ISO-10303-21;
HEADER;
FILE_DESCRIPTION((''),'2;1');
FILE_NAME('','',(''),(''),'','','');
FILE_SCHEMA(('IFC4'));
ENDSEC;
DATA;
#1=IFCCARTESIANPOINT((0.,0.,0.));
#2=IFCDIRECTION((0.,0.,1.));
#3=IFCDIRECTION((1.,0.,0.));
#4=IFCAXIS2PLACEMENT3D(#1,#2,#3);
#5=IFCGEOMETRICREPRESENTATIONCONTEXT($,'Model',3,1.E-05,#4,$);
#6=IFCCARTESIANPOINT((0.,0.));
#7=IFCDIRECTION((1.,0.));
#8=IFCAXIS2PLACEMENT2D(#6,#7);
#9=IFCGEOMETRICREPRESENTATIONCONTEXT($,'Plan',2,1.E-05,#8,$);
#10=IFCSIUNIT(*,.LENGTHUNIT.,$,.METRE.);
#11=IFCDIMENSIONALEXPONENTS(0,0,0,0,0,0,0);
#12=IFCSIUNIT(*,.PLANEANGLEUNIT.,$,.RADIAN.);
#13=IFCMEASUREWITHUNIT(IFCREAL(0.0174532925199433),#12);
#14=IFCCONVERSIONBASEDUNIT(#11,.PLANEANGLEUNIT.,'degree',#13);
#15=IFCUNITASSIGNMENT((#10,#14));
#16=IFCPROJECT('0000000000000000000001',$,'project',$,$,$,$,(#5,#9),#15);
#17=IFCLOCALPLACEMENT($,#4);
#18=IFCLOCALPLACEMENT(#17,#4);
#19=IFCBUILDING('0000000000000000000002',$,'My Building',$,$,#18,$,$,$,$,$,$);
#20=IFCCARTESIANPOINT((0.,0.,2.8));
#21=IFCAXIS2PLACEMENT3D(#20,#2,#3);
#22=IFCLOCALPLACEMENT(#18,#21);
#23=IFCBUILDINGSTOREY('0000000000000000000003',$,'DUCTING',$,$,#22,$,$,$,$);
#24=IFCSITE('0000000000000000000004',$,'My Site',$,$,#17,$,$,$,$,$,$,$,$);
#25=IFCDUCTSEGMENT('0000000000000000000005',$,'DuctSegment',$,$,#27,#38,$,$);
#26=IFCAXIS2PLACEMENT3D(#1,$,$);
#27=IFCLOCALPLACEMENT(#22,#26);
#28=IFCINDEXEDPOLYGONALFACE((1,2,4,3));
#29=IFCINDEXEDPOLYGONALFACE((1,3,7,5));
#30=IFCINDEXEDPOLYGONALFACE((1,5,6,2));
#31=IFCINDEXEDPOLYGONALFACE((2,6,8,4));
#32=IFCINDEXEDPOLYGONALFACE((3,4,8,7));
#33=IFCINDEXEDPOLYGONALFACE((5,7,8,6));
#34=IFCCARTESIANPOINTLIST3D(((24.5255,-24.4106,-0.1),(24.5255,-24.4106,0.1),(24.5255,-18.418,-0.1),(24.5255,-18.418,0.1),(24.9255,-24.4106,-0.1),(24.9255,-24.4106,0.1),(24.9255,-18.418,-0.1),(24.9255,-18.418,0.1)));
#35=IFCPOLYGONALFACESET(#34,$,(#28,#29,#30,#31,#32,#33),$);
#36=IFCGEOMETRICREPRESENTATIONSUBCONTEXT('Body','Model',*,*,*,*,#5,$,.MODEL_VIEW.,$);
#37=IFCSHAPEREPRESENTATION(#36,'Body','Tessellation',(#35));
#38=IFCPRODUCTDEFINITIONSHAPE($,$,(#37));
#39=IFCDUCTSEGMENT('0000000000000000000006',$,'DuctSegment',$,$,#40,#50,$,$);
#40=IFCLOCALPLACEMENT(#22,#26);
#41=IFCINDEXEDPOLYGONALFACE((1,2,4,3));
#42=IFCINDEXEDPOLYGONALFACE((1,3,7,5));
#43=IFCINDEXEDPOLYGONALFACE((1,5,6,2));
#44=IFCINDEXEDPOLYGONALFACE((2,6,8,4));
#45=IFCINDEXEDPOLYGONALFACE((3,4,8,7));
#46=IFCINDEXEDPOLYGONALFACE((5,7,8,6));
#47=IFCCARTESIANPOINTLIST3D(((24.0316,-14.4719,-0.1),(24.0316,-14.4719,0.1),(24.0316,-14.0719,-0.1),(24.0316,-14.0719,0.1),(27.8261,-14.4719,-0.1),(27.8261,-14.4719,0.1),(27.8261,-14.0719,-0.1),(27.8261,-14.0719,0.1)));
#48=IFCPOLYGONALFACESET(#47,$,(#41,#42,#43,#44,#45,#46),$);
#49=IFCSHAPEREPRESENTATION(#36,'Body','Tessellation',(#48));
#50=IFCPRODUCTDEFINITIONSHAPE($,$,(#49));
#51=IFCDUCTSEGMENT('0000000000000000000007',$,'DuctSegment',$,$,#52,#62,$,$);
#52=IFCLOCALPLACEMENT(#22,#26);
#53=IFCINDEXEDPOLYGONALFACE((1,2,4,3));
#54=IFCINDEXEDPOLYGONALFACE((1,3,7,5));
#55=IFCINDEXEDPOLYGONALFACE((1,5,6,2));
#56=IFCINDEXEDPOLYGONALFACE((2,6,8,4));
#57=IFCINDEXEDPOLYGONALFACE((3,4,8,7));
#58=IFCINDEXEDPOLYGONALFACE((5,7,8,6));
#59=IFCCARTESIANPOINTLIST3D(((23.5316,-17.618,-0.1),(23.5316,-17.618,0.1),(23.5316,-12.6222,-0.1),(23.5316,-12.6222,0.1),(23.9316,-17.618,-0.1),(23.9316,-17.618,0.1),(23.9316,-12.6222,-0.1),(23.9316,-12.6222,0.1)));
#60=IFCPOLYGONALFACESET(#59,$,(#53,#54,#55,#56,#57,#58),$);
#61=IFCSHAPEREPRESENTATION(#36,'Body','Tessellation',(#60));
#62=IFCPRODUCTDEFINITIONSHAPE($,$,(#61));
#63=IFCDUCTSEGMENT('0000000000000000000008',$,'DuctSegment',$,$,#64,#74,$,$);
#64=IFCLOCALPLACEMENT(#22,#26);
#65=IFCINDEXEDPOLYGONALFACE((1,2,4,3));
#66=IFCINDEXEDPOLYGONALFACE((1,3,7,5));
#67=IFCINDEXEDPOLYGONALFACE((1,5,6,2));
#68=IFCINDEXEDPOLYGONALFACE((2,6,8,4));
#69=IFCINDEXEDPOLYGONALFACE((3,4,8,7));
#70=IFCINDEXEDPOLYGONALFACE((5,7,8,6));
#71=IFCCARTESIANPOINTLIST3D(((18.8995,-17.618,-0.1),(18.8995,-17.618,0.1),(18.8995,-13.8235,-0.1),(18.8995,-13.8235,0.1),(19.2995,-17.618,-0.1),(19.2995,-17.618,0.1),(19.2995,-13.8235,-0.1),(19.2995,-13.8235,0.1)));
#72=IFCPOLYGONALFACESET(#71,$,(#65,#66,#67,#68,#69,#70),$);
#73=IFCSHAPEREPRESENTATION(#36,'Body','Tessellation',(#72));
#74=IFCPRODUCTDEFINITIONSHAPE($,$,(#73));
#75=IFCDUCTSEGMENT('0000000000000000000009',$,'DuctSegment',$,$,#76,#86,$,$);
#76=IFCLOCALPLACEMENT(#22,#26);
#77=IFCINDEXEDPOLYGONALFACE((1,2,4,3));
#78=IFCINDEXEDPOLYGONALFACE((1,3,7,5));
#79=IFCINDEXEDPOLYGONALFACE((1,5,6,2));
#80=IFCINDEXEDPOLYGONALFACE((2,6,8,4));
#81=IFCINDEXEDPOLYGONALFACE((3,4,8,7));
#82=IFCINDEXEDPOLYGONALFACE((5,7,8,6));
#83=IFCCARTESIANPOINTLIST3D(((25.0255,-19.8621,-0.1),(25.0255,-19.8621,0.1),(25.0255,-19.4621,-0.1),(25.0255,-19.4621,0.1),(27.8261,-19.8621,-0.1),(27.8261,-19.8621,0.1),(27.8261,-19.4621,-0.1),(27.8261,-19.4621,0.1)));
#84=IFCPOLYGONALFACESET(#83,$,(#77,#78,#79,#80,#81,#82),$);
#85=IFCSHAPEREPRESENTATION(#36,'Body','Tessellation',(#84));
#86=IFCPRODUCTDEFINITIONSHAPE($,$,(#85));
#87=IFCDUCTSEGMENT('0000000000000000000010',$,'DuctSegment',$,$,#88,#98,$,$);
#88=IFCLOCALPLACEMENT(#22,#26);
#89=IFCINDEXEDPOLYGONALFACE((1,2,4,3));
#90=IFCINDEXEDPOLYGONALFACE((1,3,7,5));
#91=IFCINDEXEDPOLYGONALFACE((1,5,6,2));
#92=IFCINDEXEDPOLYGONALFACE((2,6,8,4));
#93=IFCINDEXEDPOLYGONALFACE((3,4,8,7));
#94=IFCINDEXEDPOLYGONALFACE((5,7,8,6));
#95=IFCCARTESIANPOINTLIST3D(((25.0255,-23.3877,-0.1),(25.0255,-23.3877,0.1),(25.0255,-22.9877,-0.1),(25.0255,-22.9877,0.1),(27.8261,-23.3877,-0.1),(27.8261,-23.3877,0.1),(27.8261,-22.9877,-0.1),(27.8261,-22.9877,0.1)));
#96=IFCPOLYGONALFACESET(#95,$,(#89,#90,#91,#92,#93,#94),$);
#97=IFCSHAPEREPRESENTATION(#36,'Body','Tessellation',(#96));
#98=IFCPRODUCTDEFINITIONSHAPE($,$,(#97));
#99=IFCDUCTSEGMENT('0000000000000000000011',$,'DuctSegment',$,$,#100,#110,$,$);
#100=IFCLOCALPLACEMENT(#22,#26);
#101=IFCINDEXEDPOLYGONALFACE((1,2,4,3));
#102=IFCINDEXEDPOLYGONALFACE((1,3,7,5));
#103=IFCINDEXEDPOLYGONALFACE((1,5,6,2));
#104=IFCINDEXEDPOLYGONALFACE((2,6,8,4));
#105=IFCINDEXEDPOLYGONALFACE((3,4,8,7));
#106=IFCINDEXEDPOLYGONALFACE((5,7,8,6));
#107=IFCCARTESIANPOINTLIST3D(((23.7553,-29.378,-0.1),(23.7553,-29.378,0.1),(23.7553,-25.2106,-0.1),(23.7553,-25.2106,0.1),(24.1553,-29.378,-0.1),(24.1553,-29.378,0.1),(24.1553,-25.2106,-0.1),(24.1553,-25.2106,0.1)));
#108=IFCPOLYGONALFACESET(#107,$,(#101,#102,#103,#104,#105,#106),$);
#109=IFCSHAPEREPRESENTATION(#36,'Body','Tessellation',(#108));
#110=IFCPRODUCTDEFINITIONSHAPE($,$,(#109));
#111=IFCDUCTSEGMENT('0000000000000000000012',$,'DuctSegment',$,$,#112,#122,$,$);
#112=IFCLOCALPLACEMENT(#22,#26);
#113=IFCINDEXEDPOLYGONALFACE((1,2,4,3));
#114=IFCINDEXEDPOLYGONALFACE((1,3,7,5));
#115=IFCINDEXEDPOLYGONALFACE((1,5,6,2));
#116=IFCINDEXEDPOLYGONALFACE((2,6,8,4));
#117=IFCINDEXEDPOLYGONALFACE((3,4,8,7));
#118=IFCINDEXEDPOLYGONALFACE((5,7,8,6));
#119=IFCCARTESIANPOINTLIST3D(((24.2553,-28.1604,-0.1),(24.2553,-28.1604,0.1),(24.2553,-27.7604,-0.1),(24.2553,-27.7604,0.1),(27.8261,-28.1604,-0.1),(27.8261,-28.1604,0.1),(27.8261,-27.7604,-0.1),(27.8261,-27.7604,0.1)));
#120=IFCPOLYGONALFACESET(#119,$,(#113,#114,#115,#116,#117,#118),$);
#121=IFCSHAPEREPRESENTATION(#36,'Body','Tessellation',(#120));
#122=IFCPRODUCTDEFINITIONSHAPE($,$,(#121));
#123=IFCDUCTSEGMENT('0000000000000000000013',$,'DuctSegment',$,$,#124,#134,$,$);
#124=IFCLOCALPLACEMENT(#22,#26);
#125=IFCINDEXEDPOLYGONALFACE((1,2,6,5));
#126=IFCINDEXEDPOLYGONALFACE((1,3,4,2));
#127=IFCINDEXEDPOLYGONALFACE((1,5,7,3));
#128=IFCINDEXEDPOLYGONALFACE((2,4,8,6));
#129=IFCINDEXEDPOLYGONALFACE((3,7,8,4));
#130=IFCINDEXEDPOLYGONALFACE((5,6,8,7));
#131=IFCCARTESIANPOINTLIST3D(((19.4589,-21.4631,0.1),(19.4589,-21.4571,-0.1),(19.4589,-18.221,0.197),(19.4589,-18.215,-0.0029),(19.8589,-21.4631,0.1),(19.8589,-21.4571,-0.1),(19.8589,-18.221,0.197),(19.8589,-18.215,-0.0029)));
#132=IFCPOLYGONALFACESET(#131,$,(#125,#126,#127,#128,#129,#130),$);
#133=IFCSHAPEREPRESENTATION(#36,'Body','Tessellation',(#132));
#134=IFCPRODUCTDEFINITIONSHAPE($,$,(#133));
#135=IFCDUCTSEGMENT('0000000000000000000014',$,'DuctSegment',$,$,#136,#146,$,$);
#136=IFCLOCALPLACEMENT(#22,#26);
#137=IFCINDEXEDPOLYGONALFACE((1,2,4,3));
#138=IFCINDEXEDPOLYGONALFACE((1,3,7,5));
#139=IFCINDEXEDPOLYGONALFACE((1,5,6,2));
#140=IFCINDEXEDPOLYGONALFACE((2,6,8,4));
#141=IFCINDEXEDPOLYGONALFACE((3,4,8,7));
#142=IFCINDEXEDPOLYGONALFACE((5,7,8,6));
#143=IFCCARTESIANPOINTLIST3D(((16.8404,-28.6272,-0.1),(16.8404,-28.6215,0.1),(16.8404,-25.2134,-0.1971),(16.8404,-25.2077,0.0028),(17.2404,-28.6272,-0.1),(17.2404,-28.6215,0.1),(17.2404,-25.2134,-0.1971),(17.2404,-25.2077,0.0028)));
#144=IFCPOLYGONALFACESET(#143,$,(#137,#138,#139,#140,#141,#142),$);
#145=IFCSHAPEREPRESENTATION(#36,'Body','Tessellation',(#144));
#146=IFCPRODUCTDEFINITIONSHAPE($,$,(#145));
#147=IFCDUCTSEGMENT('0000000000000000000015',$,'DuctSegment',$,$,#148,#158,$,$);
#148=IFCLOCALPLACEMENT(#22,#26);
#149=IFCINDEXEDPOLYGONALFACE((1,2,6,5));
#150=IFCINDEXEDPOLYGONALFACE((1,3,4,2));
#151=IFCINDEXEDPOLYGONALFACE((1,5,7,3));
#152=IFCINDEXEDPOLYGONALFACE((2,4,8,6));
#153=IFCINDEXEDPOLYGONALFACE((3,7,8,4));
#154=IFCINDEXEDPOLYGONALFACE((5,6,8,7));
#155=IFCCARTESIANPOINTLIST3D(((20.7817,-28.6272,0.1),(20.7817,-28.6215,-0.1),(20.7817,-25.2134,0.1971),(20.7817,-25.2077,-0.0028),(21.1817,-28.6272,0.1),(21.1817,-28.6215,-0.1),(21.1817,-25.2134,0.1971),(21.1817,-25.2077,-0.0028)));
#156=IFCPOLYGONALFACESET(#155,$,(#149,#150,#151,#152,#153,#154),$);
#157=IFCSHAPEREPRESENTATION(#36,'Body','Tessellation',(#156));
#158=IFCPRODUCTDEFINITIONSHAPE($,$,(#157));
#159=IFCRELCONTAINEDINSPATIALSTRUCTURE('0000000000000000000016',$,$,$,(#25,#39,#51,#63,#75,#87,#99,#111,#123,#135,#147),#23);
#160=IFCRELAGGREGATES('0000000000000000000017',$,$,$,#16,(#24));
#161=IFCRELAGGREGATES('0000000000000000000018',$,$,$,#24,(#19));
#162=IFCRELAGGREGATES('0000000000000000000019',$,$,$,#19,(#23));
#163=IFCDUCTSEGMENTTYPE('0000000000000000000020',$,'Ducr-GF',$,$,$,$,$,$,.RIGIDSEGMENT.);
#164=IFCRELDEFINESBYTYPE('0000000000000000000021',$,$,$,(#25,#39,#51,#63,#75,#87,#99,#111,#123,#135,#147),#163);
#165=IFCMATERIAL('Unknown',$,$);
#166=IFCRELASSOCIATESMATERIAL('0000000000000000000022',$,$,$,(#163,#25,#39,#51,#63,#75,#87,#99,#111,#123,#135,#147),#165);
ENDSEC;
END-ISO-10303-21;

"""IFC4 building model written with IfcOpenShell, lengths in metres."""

from ifc_helpers import new_model, entity, si_unit, converted_unit, frame, origin_with_axes, origin_2d_with_axis, place, context, subcontext, project, spatial, rectangle, extrude, material, material_profile, profile_set, profile_usage, type_object, element, save


model = new_model("IFC4")

# Units and contexts
model_context = context("Model", 3, precision=1e-05, world=origin_with_axes())
plan_context = context("Plan", 2, precision=1e-05, world=origin_2d_with_axis())
body_context = subcontext(model_context, "Body", "Model", "MODEL_VIEW")
ifc_project = project(units=[si_unit("LENGTHUNIT", "METRE"), converted_unit("PLANEANGLEUNIT", "degree", entity("IfcReal", 0.0174532925199433), si_unit("PLANEANGLEUNIT", "RADIAN"), dimensions=[0, 0, 0, 0, 0, 0, 0])], contexts=[model_context, plan_context])

# Site, building, storey
site_placement = place(None, origin_with_axes())
site = spatial("IfcSite", under=ifc_project, at=site_placement, Name="My Site")
building_placement = place(site_placement, origin_with_axes())
building = spatial("IfcBuilding", under=site, at=building_placement, Name="My Building")
storey_placement = place(building_placement, frame((0.0, 0.0, 2.8), z_axis=(0.0, 0.0, 1.0), x_axis=(1.0, 0.0, 0.0)))
storey = spatial("IfcBuildingStorey", under=building, at=storey_placement, Name="DUCTING")

# Duct segments
ifc_material = material(Name="Unknown")
ifc_material_profile_1 = material_profile(ifc_material, rectangle(XDim=0.4, YDim=0.2))
ifc_profile_set_1 = profile_set([ifc_material_profile_1])
ifc_profile_usage_1 = profile_usage(ifc_profile_set_1, cardinal=5)
duct_segment_type = type_object("IfcDuctSegmentType", Name="Ducr-GF", PredefinedType="RIGIDSEGMENT", material=ifc_profile_set_1)
duct_segment_1_placement = place(storey_placement, frame((24.7255, -18.418, 0.0), z_axis=(0.0, -1.0, 0.0), x_axis=(1.0, 0.0, 0.0)))
element("IfcDuctSegment", 1, at=duct_segment_1_placement, inside=storey, type_object=duct_segment_type, material=ifc_profile_usage_1, Name="DuctSegment", context=body_context, shape_type="SweptSolid", body=[
    extrude(rectangle(XDim=0.4, YDim=0.2), origin_with_axes(), (0.0, 0.0, 1.0), 5.9926),
])
ifc_profile_usage_2 = profile_usage(ifc_profile_set_1, cardinal=5)
duct_segment_2_placement = place(storey_placement, frame((24.0316, -14.2719, 0.0), z_axis=(1.0, 0.0, 0.0), x_axis=(0.0, 1.0, 0.0)))
element("IfcDuctSegment", 2, at=duct_segment_2_placement, inside=storey, type_object=duct_segment_type, material=ifc_profile_usage_2, Name="DuctSegment", context=body_context, shape_type="SweptSolid", body=[
    extrude(rectangle(XDim=0.4, YDim=0.2), origin_with_axes(), (0.0, 0.0, 1.0), 3.7945),
])
ifc_profile_usage_3 = profile_usage(ifc_profile_set_1, cardinal=5)
duct_segment_3_placement = place(storey_placement, frame((23.7316, -17.618, 0.0), z_axis=(0.0, 1.0, 0.0), x_axis=(-1.0, 0.0, 0.0)))
element("IfcDuctSegment", 3, at=duct_segment_3_placement, inside=storey, type_object=duct_segment_type, material=ifc_profile_usage_3, Name="DuctSegment", context=body_context, shape_type="SweptSolid", body=[
    extrude(rectangle(XDim=0.4, YDim=0.2), origin_with_axes(), (0.0, 0.0, 1.0), 4.9959),
])
ifc_profile_usage_4 = profile_usage(ifc_profile_set_1, cardinal=5)
duct_segment_4_placement = place(storey_placement, frame((19.0995, -17.618, 0.0), z_axis=(0.0, 1.0, 0.0), x_axis=(-1.0, 0.0, 0.0)))
element("IfcDuctSegment", 4, at=duct_segment_4_placement, inside=storey, type_object=duct_segment_type, material=ifc_profile_usage_4, Name="DuctSegment", context=body_context, shape_type="SweptSolid", body=[
    extrude(rectangle(XDim=0.4, YDim=0.2), origin_with_axes(), (0.0, 0.0, 1.0), 3.7945),
])
ifc_profile_usage_5 = profile_usage(ifc_profile_set_1, cardinal=5)
duct_segment_5_placement = place(storey_placement, frame((25.0255, -19.6621, 0.0), z_axis=(1.0, 0.0, 0.0), x_axis=(0.0, 1.0, 0.0)))
element("IfcDuctSegment", 5, at=duct_segment_5_placement, inside=storey, type_object=duct_segment_type, material=ifc_profile_usage_5, Name="DuctSegment", context=body_context, shape_type="SweptSolid", body=[
    extrude(rectangle(XDim=0.4, YDim=0.2), origin_with_axes(), (0.0, 0.0, 1.0), 2.8006),
])
ifc_profile_usage_6 = profile_usage(ifc_profile_set_1, cardinal=5)
duct_segment_6_placement = place(storey_placement, frame((25.0255, -23.1877, 0.0), z_axis=(1.0, 0.0, 0.0), x_axis=(0.0, 1.0, 0.0)))
element("IfcDuctSegment", 6, at=duct_segment_6_placement, inside=storey, type_object=duct_segment_type, material=ifc_profile_usage_6, Name="DuctSegment", context=body_context, shape_type="SweptSolid", body=[
    extrude(rectangle(XDim=0.4, YDim=0.2), origin_with_axes(), (0.0, 0.0, 1.0), 2.8006),
])
ifc_profile_usage_7 = profile_usage(ifc_profile_set_1, cardinal=5)
duct_segment_7_placement = place(storey_placement, frame((23.9553, -25.2106, 0.0), z_axis=(0.0, -1.0, 0.0), x_axis=(1.0, 0.0, 0.0)))
element("IfcDuctSegment", 7, at=duct_segment_7_placement, inside=storey, type_object=duct_segment_type, material=ifc_profile_usage_7, Name="DuctSegment", context=body_context, shape_type="SweptSolid", body=[
    extrude(rectangle(XDim=0.4, YDim=0.2), origin_with_axes(), (0.0, 0.0, 1.0), 4.1674),
])
ifc_profile_usage_8 = profile_usage(ifc_profile_set_1, cardinal=5)
duct_segment_8_placement = place(storey_placement, frame((24.2553, -27.9604, 0.0), z_axis=(1.0, 0.0, 0.0), x_axis=(0.0, 1.0, 0.0)))
element("IfcDuctSegment", 8, at=duct_segment_8_placement, inside=storey, type_object=duct_segment_type, material=ifc_profile_usage_8, Name="DuctSegment", context=body_context, shape_type="SweptSolid", body=[
    extrude(rectangle(XDim=0.4, YDim=0.2), origin_with_axes(), (0.0, 0.0, 1.0), 3.5708),
])
ifc_profile_usage_9 = profile_usage(ifc_profile_set_1, cardinal=5)
duct_segment_9_placement = place(storey_placement, frame((19.6589, -18.218, 0.097), z_axis=(-0.000001, -0.999553, -0.029908), x_axis=(1.0, -0.000001, 0.0)))
element("IfcDuctSegment", 9, at=duct_segment_9_placement, inside=storey, type_object=duct_segment_type, material=ifc_profile_usage_9, Name="DuctSegment", context=body_context, shape_type="SweptSolid", body=[
    extrude(rectangle(XDim=0.4, YDim=0.2), origin_with_axes(), (0.0, 0.0, 1.0), 3.2435),
])
ifc_profile_usage_10 = profile_usage(ifc_profile_set_1, cardinal=5)
duct_segment_10_placement = place(storey_placement, frame((17.0404, -25.2106, -0.0972), z_axis=(0.0, -0.999595, 0.028448), x_axis=(1.0, 0.0, 0.0)))
element("IfcDuctSegment", 10, at=duct_segment_10_placement, inside=storey, type_object=duct_segment_type, material=ifc_profile_usage_10, Name="DuctSegment", context=body_context, shape_type="SweptSolid", body=[
    extrude(rectangle(XDim=0.4, YDim=0.2), origin_with_axes(), (0.0, 0.0, 1.0), 3.4152),
])
ifc_profile_usage_11 = profile_usage(ifc_profile_set_1, cardinal=5)
duct_segment_11_placement = place(storey_placement, frame((20.9817, -25.2106, 0.0972), z_axis=(-0.000001, -0.999595, -0.028447), x_axis=(1.0, -0.000001, 0.0)))
element("IfcDuctSegment", 11, at=duct_segment_11_placement, inside=storey, type_object=duct_segment_type, material=ifc_profile_usage_11, Name="DuctSegment", context=body_context, shape_type="SweptSolid", body=[
    extrude(rectangle(XDim=0.4, YDim=0.2), origin_with_axes(), (0.0, 0.0, 1.0), 3.4152),
])

save(model, "model.ifc")
